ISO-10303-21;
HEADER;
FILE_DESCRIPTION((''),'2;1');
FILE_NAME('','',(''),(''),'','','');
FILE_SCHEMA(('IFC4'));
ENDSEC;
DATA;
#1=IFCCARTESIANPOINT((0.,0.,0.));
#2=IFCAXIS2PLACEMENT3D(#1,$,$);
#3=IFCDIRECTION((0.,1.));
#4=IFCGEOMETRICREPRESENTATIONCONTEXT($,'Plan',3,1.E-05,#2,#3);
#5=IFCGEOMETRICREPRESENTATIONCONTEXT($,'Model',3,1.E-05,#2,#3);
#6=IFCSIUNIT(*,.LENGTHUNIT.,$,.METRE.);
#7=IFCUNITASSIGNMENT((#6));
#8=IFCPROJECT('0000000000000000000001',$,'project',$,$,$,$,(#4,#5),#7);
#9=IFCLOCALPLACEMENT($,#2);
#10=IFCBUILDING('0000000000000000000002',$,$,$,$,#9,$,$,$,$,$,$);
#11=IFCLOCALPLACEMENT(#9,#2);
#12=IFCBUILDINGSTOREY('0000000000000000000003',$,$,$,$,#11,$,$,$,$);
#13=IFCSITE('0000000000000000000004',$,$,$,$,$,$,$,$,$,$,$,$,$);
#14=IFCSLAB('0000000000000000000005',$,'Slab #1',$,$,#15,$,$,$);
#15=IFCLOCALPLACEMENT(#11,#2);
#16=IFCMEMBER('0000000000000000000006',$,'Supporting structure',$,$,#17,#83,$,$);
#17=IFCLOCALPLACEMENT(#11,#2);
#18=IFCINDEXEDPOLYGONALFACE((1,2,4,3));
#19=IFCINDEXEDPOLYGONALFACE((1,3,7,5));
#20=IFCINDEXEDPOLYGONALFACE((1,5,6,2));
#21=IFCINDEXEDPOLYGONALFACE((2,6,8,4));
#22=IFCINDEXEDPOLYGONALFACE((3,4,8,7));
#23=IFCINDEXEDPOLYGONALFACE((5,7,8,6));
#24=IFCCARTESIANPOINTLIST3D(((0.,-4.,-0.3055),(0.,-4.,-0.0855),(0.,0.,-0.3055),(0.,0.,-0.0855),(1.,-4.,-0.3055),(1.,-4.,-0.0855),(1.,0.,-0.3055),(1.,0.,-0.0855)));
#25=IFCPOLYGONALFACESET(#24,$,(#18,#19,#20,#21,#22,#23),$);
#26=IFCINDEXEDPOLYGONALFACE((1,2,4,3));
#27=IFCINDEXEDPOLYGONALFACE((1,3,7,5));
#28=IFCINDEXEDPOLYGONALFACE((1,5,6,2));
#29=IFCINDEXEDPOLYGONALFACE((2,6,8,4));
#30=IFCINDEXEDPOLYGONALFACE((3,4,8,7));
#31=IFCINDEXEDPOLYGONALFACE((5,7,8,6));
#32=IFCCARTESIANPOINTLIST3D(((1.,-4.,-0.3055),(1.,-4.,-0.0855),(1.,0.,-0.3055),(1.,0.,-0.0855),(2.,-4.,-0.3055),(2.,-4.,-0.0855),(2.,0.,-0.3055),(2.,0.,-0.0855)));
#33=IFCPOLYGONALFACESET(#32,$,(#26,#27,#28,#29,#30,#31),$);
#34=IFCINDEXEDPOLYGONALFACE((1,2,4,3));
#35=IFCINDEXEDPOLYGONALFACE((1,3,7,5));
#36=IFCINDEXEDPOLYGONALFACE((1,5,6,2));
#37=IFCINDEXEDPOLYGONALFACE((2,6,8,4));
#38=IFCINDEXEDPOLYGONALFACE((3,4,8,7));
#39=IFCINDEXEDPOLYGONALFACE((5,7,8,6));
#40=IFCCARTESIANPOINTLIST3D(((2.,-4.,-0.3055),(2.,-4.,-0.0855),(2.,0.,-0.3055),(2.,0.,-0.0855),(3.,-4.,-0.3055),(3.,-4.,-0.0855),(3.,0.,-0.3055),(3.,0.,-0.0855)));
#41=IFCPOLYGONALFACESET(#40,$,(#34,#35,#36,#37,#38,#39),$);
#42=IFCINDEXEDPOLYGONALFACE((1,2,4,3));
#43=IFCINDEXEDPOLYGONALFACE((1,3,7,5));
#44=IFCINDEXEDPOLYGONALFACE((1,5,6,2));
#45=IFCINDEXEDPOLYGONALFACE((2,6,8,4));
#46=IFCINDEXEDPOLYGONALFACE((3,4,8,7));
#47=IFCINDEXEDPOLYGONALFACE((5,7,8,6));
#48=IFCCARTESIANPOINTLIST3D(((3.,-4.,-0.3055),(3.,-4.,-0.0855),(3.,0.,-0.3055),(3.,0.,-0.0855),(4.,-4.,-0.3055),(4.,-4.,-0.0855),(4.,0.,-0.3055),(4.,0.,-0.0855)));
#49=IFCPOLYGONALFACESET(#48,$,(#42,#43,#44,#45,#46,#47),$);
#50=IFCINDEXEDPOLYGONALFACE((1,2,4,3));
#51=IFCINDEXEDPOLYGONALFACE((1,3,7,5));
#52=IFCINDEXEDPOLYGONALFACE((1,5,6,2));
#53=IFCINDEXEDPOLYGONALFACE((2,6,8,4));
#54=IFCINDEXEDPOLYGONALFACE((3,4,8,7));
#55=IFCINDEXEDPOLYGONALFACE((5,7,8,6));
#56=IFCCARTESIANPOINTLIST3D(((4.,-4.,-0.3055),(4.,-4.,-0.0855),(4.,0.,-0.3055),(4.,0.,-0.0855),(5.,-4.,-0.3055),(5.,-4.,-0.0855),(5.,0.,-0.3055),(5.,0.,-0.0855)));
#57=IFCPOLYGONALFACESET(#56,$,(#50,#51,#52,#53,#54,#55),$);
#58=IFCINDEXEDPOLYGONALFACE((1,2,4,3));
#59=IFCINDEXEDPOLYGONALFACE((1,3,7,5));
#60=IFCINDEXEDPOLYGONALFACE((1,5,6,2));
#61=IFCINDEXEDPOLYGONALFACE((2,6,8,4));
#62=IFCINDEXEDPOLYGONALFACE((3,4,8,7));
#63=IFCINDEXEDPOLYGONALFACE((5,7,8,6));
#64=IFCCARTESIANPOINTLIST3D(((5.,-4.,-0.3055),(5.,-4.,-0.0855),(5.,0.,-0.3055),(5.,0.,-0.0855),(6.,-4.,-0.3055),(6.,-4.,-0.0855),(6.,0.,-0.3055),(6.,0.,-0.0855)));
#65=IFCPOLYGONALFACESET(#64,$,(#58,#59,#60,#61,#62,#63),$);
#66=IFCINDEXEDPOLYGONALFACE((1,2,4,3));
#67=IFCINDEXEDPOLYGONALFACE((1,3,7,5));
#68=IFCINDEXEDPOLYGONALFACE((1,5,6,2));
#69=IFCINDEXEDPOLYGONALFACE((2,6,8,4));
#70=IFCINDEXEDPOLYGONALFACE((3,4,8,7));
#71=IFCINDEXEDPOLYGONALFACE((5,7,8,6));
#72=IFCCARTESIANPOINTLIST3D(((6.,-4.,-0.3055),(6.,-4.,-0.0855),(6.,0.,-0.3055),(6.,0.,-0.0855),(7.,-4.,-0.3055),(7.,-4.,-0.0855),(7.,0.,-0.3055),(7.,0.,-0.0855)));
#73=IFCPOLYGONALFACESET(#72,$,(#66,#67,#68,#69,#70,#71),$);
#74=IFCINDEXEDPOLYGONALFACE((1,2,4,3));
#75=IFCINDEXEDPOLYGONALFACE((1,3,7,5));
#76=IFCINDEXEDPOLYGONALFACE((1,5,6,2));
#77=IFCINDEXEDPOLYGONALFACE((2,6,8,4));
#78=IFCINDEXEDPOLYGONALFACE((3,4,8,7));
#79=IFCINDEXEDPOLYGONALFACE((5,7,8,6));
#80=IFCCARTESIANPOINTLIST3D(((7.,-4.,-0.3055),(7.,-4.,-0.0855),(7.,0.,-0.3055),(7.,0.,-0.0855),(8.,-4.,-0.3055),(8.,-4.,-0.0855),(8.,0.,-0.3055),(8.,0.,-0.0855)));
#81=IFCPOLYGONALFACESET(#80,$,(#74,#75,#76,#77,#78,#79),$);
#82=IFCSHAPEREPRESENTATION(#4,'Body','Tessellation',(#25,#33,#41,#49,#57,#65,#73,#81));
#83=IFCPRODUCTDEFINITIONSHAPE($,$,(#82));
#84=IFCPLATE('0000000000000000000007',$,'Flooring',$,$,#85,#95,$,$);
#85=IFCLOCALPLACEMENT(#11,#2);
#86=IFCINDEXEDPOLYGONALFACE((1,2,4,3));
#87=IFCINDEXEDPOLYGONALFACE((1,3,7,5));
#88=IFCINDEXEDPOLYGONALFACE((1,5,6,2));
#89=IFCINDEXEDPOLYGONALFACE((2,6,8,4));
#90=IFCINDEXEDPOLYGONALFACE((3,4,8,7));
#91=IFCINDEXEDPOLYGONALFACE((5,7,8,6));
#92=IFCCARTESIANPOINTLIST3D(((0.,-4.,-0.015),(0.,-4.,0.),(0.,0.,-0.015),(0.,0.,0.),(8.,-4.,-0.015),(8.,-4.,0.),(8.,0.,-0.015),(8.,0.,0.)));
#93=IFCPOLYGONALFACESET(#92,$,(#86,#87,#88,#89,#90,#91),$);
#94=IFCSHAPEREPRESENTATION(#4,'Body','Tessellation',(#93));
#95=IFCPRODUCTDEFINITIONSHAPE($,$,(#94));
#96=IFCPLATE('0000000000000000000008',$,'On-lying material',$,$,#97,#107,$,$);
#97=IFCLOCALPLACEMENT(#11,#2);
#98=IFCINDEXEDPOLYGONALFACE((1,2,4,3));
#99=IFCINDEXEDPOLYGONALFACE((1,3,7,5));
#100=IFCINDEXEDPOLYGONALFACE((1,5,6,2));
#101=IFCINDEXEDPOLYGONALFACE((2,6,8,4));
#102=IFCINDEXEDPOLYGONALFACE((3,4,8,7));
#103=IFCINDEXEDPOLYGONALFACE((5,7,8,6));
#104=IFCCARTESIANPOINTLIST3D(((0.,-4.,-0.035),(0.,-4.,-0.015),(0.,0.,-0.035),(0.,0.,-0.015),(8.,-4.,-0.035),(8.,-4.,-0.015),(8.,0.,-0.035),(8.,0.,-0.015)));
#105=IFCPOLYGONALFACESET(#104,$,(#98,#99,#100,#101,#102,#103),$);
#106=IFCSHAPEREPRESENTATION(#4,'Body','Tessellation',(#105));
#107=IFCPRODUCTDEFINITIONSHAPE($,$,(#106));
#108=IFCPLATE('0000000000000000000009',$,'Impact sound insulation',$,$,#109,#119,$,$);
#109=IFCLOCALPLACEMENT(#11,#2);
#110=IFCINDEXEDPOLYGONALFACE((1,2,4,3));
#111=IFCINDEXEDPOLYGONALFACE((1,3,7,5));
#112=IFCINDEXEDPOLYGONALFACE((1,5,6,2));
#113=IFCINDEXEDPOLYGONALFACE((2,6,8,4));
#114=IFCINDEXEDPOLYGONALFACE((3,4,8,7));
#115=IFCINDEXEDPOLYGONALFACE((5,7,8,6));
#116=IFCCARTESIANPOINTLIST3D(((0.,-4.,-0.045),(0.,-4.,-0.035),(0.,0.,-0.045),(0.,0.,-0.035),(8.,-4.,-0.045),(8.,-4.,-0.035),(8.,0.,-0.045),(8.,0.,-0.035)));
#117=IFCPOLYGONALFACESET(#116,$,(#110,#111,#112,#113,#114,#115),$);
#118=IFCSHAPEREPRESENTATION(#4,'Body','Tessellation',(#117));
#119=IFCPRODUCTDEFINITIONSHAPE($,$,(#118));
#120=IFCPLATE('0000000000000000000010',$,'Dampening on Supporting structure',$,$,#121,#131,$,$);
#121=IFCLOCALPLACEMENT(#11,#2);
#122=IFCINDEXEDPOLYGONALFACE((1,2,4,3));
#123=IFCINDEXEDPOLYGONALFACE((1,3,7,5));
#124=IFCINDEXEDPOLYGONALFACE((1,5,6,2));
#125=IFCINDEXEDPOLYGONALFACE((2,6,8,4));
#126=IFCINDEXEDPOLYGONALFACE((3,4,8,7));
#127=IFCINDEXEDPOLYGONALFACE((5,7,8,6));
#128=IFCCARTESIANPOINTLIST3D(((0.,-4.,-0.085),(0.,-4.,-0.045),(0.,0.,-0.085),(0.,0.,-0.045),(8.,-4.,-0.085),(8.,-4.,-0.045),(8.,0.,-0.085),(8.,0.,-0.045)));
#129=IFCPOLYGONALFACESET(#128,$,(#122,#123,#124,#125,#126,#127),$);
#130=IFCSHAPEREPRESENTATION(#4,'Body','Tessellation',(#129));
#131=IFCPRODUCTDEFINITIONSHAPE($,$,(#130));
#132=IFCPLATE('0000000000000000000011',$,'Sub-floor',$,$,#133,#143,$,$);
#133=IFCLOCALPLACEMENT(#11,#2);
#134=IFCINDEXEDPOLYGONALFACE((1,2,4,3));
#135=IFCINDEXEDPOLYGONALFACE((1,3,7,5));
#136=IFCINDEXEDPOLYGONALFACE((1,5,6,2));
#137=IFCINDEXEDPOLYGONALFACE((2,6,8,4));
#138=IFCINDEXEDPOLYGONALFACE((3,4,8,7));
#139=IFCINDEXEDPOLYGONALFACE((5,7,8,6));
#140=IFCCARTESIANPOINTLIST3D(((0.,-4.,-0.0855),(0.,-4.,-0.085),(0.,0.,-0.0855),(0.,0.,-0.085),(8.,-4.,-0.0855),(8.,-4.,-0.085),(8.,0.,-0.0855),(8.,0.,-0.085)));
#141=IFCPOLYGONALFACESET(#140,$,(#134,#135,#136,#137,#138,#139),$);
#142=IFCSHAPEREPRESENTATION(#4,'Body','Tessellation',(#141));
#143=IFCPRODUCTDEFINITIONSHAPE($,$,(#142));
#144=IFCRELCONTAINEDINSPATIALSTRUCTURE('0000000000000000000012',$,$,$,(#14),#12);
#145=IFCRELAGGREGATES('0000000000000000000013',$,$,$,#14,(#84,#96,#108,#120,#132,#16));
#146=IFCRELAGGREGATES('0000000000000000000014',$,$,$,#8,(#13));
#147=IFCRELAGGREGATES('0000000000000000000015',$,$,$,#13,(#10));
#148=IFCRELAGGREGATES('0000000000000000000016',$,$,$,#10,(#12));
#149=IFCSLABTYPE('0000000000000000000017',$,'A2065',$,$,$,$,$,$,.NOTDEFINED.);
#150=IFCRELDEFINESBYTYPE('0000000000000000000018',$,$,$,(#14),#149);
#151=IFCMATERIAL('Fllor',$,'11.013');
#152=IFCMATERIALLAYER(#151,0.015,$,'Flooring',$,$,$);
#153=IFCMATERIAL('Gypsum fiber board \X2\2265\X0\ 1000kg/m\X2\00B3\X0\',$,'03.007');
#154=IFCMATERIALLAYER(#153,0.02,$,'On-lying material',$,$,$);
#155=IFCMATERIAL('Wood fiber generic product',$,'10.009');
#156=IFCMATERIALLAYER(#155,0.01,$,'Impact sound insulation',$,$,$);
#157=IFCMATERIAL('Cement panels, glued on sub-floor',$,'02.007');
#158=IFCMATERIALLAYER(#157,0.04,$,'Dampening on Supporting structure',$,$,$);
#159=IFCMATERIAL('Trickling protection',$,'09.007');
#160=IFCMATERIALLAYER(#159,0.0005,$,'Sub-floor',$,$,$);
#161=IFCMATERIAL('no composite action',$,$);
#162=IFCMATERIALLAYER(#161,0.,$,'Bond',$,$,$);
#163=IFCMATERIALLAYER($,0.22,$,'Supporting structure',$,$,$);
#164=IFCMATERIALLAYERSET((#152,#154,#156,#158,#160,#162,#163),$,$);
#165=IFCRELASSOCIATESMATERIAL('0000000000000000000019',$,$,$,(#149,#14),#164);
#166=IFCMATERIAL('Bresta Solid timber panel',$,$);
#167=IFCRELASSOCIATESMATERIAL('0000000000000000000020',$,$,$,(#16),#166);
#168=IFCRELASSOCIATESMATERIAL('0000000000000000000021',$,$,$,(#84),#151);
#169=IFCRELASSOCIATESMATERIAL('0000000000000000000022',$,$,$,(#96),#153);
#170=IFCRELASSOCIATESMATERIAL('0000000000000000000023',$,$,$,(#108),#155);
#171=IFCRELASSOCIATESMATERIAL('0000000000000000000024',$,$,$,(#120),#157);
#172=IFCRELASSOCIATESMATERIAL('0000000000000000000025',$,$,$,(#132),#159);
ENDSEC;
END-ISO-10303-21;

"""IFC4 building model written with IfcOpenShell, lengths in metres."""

from ifc_helpers import new_model, si_unit, direction, frame, frame_2d, origin, origin_with_axes, place, context, project, spatial, rectangle, extrude, material, layer, layer_set, type_object, element, aggregate, save


model = new_model("IFC4")

# Units and contexts
plan_context = context("Plan", 3, precision=1e-05, world=origin(), true_north=direction((0.0, 1.0)))
model_context = context("Model", 3, precision=1e-05, world=origin(), true_north=direction((0.0, 1.0)))
ifc_project = project(units=[si_unit("LENGTHUNIT", "METRE")], contexts=[plan_context, model_context])

# Site, building, storey
site = spatial("IfcSite", under=ifc_project)
building_placement = place(None, origin())
building = spatial("IfcBuilding", under=site, at=building_placement)
storey_placement = place(building_placement, origin())
storey = spatial("IfcBuildingStorey", under=building, at=storey_placement)

# Slab, member, plates
ifc_material_1 = material(Name="Fllor", Category="11.013")
ifc_layer_1 = layer(ifc_material_1, 0.015, Name="Flooring")
ifc_material_2 = material(Name="Gypsum fiber board ≥ 1000kg/m³", Category="03.007")
ifc_layer_2 = layer(ifc_material_2, 0.02, Name="On-lying material")
ifc_material_3 = material(Name="Wood fiber generic product", Category="10.009")
ifc_layer_3 = layer(ifc_material_3, 0.01, Name="Impact sound insulation")
ifc_material_4 = material(Name="Cement panels, glued on sub-floor", Category="02.007")
ifc_layer_4 = layer(ifc_material_4, 0.04, Name="Dampening on Supporting structure")
ifc_material_5 = material(Name="Trickling protection", Category="09.007")
ifc_layer_5 = layer(ifc_material_5, 0.0005, Name="Sub-floor")
ifc_material_6 = material(Name="no composite action")
ifc_layer_6 = layer(ifc_material_6, 0.0, Name="Bond")
ifc_layer_7 = layer(None, 0.22, Name="Supporting structure")
ifc_layer_set = layer_set([ifc_layer_1, ifc_layer_2, ifc_layer_3, ifc_layer_4, ifc_layer_5, ifc_layer_6, ifc_layer_7])
slab_type = type_object("IfcSlabType", Name="A2065", PredefinedType="NOTDEFINED", material=ifc_layer_set)
slab_placement = place(None, frame((0.0, 0.0, 0.0), z_axis=(0.0, 0.0, -1.0), x_axis=(1.0, 0.0, 0.0)))
slab = element("IfcSlab", 1, at=slab_placement, inside=storey, type_object=slab_type, material=ifc_layer_set, Name="Slab #1")
ifc_material_7 = material(Name="Bresta Solid timber panel")
member_placement = place(slab_placement, origin())
member = element("IfcMember", 2, at=member_placement, material=ifc_material_7, Name="Supporting structure", context=plan_context, shape_type="SweptSolid", body=[
    extrude(rectangle(XDim=1.0, YDim=0.22, at=frame_2d((0.5, 0.11), x_axis=(1.0, 0.0))), frame((0.0, 4.0, 0.0855), z_axis=(0.0, -1.0, 0.0), x_axis=(1.0, 0.0, 0.0)), (0.0, 0.0, 1.0), 4.0),
    extrude(rectangle(XDim=1.0, YDim=0.22, at=frame_2d((0.5, 0.11), x_axis=(1.0, 0.0))), frame((1.0, 4.0, 0.0855), z_axis=(0.0, -1.0, 0.0), x_axis=(1.0, 0.0, 0.0)), (0.0, 0.0, 1.0), 4.0),
    extrude(rectangle(XDim=1.0, YDim=0.22, at=frame_2d((0.5, 0.11), x_axis=(1.0, 0.0))), frame((2.0, 4.0, 0.0855), z_axis=(0.0, -1.0, 0.0), x_axis=(1.0, 0.0, 0.0)), (0.0, 0.0, 1.0), 4.0),
    extrude(rectangle(XDim=1.0, YDim=0.22, at=frame_2d((0.5, 0.11), x_axis=(1.0, 0.0))), frame((3.0, 4.0, 0.0855), z_axis=(0.0, -1.0, 0.0), x_axis=(1.0, 0.0, 0.0)), (0.0, 0.0, 1.0), 4.0),
    extrude(rectangle(XDim=1.0, YDim=0.22, at=frame_2d((0.5, 0.11), x_axis=(1.0, 0.0))), frame((4.0, 4.0, 0.0855), z_axis=(0.0, -1.0, 0.0), x_axis=(1.0, 0.0, 0.0)), (0.0, 0.0, 1.0), 4.0),
    extrude(rectangle(XDim=1.0, YDim=0.22, at=frame_2d((0.5, 0.11), x_axis=(1.0, 0.0))), frame((5.0, 4.0, 0.0855), z_axis=(0.0, -1.0, 0.0), x_axis=(1.0, 0.0, 0.0)), (0.0, 0.0, 1.0), 4.0),
    extrude(rectangle(XDim=1.0, YDim=0.22, at=frame_2d((0.5, 0.11), x_axis=(1.0, 0.0))), frame((6.0, 4.0, 0.0855), z_axis=(0.0, -1.0, 0.0), x_axis=(1.0, 0.0, 0.0)), (0.0, 0.0, 1.0), 4.0),
    extrude(rectangle(XDim=1.0, YDim=0.22, at=frame_2d((0.5, 0.11), x_axis=(1.0, 0.0))), frame((7.0, 4.0, 0.0855), z_axis=(0.0, -1.0, 0.0), x_axis=(1.0, 0.0, 0.0)), (0.0, 0.0, 1.0), 4.0),
])
plate_1_placement = place(slab_placement, origin())
plate_1 = element("IfcPlate", 3, at=plate_1_placement, material=ifc_material_1, Name="Flooring", context=plan_context, shape_type="SweptSolid", body=[
    extrude(rectangle(XDim=8.0, YDim=4.0, at=frame_2d((4.0, 2.0), x_axis=(1.0, 0.0))), origin_with_axes(), (0.0, 0.0, 1.0), 0.015),
])
plate_2_placement = place(slab_placement, origin())
plate_2 = element("IfcPlate", 4, at=plate_2_placement, material=ifc_material_2, Name="On-lying material", context=plan_context, shape_type="SweptSolid", body=[
    extrude(rectangle(XDim=8.0, YDim=4.0, at=frame_2d((4.0, 2.0), x_axis=(1.0, 0.0))), frame((0.0, 0.0, 0.015), z_axis=(0.0, 0.0, 1.0), x_axis=(1.0, 0.0, 0.0)), (0.0, 0.0, 1.0), 0.02),
])
plate_3_placement = place(slab_placement, origin())
plate_3 = element("IfcPlate", 5, at=plate_3_placement, material=ifc_material_3, Name="Impact sound insulation", context=plan_context, shape_type="SweptSolid", body=[
    extrude(rectangle(XDim=8.0, YDim=4.0, at=frame_2d((4.0, 2.0), x_axis=(1.0, 0.0))), frame((0.0, 0.0, 0.035), z_axis=(0.0, 0.0, 1.0), x_axis=(1.0, 0.0, 0.0)), (0.0, 0.0, 1.0), 0.01),
])
plate_4_placement = place(slab_placement, origin())
plate_4 = element("IfcPlate", 6, at=plate_4_placement, material=ifc_material_4, Name="Dampening on Supporting structure", context=plan_context, shape_type="SweptSolid", body=[
    extrude(rectangle(XDim=8.0, YDim=4.0, at=frame_2d((4.0, 2.0), x_axis=(1.0, 0.0))), frame((0.0, 0.0, 0.045), z_axis=(0.0, 0.0, 1.0), x_axis=(1.0, 0.0, 0.0)), (0.0, 0.0, 1.0), 0.04),
])
plate_5_placement = place(slab_placement, origin())
plate_5 = element("IfcPlate", 7, at=plate_5_placement, material=ifc_material_5, Name="Sub-floor", context=plan_context, shape_type="SweptSolid", body=[
    extrude(rectangle(XDim=8.0, YDim=4.0, at=frame_2d((4.0, 2.0), x_axis=(1.0, 0.0))), frame((0.0, 0.0, 0.085), z_axis=(0.0, 0.0, 1.0), x_axis=(1.0, 0.0, 0.0)), (0.0, 0.0, 1.0), 0.0005),
])
aggregate(slab, [plate_1, plate_2, plate_3, plate_4, plate_5, member])

save(model, "model.ifc")
